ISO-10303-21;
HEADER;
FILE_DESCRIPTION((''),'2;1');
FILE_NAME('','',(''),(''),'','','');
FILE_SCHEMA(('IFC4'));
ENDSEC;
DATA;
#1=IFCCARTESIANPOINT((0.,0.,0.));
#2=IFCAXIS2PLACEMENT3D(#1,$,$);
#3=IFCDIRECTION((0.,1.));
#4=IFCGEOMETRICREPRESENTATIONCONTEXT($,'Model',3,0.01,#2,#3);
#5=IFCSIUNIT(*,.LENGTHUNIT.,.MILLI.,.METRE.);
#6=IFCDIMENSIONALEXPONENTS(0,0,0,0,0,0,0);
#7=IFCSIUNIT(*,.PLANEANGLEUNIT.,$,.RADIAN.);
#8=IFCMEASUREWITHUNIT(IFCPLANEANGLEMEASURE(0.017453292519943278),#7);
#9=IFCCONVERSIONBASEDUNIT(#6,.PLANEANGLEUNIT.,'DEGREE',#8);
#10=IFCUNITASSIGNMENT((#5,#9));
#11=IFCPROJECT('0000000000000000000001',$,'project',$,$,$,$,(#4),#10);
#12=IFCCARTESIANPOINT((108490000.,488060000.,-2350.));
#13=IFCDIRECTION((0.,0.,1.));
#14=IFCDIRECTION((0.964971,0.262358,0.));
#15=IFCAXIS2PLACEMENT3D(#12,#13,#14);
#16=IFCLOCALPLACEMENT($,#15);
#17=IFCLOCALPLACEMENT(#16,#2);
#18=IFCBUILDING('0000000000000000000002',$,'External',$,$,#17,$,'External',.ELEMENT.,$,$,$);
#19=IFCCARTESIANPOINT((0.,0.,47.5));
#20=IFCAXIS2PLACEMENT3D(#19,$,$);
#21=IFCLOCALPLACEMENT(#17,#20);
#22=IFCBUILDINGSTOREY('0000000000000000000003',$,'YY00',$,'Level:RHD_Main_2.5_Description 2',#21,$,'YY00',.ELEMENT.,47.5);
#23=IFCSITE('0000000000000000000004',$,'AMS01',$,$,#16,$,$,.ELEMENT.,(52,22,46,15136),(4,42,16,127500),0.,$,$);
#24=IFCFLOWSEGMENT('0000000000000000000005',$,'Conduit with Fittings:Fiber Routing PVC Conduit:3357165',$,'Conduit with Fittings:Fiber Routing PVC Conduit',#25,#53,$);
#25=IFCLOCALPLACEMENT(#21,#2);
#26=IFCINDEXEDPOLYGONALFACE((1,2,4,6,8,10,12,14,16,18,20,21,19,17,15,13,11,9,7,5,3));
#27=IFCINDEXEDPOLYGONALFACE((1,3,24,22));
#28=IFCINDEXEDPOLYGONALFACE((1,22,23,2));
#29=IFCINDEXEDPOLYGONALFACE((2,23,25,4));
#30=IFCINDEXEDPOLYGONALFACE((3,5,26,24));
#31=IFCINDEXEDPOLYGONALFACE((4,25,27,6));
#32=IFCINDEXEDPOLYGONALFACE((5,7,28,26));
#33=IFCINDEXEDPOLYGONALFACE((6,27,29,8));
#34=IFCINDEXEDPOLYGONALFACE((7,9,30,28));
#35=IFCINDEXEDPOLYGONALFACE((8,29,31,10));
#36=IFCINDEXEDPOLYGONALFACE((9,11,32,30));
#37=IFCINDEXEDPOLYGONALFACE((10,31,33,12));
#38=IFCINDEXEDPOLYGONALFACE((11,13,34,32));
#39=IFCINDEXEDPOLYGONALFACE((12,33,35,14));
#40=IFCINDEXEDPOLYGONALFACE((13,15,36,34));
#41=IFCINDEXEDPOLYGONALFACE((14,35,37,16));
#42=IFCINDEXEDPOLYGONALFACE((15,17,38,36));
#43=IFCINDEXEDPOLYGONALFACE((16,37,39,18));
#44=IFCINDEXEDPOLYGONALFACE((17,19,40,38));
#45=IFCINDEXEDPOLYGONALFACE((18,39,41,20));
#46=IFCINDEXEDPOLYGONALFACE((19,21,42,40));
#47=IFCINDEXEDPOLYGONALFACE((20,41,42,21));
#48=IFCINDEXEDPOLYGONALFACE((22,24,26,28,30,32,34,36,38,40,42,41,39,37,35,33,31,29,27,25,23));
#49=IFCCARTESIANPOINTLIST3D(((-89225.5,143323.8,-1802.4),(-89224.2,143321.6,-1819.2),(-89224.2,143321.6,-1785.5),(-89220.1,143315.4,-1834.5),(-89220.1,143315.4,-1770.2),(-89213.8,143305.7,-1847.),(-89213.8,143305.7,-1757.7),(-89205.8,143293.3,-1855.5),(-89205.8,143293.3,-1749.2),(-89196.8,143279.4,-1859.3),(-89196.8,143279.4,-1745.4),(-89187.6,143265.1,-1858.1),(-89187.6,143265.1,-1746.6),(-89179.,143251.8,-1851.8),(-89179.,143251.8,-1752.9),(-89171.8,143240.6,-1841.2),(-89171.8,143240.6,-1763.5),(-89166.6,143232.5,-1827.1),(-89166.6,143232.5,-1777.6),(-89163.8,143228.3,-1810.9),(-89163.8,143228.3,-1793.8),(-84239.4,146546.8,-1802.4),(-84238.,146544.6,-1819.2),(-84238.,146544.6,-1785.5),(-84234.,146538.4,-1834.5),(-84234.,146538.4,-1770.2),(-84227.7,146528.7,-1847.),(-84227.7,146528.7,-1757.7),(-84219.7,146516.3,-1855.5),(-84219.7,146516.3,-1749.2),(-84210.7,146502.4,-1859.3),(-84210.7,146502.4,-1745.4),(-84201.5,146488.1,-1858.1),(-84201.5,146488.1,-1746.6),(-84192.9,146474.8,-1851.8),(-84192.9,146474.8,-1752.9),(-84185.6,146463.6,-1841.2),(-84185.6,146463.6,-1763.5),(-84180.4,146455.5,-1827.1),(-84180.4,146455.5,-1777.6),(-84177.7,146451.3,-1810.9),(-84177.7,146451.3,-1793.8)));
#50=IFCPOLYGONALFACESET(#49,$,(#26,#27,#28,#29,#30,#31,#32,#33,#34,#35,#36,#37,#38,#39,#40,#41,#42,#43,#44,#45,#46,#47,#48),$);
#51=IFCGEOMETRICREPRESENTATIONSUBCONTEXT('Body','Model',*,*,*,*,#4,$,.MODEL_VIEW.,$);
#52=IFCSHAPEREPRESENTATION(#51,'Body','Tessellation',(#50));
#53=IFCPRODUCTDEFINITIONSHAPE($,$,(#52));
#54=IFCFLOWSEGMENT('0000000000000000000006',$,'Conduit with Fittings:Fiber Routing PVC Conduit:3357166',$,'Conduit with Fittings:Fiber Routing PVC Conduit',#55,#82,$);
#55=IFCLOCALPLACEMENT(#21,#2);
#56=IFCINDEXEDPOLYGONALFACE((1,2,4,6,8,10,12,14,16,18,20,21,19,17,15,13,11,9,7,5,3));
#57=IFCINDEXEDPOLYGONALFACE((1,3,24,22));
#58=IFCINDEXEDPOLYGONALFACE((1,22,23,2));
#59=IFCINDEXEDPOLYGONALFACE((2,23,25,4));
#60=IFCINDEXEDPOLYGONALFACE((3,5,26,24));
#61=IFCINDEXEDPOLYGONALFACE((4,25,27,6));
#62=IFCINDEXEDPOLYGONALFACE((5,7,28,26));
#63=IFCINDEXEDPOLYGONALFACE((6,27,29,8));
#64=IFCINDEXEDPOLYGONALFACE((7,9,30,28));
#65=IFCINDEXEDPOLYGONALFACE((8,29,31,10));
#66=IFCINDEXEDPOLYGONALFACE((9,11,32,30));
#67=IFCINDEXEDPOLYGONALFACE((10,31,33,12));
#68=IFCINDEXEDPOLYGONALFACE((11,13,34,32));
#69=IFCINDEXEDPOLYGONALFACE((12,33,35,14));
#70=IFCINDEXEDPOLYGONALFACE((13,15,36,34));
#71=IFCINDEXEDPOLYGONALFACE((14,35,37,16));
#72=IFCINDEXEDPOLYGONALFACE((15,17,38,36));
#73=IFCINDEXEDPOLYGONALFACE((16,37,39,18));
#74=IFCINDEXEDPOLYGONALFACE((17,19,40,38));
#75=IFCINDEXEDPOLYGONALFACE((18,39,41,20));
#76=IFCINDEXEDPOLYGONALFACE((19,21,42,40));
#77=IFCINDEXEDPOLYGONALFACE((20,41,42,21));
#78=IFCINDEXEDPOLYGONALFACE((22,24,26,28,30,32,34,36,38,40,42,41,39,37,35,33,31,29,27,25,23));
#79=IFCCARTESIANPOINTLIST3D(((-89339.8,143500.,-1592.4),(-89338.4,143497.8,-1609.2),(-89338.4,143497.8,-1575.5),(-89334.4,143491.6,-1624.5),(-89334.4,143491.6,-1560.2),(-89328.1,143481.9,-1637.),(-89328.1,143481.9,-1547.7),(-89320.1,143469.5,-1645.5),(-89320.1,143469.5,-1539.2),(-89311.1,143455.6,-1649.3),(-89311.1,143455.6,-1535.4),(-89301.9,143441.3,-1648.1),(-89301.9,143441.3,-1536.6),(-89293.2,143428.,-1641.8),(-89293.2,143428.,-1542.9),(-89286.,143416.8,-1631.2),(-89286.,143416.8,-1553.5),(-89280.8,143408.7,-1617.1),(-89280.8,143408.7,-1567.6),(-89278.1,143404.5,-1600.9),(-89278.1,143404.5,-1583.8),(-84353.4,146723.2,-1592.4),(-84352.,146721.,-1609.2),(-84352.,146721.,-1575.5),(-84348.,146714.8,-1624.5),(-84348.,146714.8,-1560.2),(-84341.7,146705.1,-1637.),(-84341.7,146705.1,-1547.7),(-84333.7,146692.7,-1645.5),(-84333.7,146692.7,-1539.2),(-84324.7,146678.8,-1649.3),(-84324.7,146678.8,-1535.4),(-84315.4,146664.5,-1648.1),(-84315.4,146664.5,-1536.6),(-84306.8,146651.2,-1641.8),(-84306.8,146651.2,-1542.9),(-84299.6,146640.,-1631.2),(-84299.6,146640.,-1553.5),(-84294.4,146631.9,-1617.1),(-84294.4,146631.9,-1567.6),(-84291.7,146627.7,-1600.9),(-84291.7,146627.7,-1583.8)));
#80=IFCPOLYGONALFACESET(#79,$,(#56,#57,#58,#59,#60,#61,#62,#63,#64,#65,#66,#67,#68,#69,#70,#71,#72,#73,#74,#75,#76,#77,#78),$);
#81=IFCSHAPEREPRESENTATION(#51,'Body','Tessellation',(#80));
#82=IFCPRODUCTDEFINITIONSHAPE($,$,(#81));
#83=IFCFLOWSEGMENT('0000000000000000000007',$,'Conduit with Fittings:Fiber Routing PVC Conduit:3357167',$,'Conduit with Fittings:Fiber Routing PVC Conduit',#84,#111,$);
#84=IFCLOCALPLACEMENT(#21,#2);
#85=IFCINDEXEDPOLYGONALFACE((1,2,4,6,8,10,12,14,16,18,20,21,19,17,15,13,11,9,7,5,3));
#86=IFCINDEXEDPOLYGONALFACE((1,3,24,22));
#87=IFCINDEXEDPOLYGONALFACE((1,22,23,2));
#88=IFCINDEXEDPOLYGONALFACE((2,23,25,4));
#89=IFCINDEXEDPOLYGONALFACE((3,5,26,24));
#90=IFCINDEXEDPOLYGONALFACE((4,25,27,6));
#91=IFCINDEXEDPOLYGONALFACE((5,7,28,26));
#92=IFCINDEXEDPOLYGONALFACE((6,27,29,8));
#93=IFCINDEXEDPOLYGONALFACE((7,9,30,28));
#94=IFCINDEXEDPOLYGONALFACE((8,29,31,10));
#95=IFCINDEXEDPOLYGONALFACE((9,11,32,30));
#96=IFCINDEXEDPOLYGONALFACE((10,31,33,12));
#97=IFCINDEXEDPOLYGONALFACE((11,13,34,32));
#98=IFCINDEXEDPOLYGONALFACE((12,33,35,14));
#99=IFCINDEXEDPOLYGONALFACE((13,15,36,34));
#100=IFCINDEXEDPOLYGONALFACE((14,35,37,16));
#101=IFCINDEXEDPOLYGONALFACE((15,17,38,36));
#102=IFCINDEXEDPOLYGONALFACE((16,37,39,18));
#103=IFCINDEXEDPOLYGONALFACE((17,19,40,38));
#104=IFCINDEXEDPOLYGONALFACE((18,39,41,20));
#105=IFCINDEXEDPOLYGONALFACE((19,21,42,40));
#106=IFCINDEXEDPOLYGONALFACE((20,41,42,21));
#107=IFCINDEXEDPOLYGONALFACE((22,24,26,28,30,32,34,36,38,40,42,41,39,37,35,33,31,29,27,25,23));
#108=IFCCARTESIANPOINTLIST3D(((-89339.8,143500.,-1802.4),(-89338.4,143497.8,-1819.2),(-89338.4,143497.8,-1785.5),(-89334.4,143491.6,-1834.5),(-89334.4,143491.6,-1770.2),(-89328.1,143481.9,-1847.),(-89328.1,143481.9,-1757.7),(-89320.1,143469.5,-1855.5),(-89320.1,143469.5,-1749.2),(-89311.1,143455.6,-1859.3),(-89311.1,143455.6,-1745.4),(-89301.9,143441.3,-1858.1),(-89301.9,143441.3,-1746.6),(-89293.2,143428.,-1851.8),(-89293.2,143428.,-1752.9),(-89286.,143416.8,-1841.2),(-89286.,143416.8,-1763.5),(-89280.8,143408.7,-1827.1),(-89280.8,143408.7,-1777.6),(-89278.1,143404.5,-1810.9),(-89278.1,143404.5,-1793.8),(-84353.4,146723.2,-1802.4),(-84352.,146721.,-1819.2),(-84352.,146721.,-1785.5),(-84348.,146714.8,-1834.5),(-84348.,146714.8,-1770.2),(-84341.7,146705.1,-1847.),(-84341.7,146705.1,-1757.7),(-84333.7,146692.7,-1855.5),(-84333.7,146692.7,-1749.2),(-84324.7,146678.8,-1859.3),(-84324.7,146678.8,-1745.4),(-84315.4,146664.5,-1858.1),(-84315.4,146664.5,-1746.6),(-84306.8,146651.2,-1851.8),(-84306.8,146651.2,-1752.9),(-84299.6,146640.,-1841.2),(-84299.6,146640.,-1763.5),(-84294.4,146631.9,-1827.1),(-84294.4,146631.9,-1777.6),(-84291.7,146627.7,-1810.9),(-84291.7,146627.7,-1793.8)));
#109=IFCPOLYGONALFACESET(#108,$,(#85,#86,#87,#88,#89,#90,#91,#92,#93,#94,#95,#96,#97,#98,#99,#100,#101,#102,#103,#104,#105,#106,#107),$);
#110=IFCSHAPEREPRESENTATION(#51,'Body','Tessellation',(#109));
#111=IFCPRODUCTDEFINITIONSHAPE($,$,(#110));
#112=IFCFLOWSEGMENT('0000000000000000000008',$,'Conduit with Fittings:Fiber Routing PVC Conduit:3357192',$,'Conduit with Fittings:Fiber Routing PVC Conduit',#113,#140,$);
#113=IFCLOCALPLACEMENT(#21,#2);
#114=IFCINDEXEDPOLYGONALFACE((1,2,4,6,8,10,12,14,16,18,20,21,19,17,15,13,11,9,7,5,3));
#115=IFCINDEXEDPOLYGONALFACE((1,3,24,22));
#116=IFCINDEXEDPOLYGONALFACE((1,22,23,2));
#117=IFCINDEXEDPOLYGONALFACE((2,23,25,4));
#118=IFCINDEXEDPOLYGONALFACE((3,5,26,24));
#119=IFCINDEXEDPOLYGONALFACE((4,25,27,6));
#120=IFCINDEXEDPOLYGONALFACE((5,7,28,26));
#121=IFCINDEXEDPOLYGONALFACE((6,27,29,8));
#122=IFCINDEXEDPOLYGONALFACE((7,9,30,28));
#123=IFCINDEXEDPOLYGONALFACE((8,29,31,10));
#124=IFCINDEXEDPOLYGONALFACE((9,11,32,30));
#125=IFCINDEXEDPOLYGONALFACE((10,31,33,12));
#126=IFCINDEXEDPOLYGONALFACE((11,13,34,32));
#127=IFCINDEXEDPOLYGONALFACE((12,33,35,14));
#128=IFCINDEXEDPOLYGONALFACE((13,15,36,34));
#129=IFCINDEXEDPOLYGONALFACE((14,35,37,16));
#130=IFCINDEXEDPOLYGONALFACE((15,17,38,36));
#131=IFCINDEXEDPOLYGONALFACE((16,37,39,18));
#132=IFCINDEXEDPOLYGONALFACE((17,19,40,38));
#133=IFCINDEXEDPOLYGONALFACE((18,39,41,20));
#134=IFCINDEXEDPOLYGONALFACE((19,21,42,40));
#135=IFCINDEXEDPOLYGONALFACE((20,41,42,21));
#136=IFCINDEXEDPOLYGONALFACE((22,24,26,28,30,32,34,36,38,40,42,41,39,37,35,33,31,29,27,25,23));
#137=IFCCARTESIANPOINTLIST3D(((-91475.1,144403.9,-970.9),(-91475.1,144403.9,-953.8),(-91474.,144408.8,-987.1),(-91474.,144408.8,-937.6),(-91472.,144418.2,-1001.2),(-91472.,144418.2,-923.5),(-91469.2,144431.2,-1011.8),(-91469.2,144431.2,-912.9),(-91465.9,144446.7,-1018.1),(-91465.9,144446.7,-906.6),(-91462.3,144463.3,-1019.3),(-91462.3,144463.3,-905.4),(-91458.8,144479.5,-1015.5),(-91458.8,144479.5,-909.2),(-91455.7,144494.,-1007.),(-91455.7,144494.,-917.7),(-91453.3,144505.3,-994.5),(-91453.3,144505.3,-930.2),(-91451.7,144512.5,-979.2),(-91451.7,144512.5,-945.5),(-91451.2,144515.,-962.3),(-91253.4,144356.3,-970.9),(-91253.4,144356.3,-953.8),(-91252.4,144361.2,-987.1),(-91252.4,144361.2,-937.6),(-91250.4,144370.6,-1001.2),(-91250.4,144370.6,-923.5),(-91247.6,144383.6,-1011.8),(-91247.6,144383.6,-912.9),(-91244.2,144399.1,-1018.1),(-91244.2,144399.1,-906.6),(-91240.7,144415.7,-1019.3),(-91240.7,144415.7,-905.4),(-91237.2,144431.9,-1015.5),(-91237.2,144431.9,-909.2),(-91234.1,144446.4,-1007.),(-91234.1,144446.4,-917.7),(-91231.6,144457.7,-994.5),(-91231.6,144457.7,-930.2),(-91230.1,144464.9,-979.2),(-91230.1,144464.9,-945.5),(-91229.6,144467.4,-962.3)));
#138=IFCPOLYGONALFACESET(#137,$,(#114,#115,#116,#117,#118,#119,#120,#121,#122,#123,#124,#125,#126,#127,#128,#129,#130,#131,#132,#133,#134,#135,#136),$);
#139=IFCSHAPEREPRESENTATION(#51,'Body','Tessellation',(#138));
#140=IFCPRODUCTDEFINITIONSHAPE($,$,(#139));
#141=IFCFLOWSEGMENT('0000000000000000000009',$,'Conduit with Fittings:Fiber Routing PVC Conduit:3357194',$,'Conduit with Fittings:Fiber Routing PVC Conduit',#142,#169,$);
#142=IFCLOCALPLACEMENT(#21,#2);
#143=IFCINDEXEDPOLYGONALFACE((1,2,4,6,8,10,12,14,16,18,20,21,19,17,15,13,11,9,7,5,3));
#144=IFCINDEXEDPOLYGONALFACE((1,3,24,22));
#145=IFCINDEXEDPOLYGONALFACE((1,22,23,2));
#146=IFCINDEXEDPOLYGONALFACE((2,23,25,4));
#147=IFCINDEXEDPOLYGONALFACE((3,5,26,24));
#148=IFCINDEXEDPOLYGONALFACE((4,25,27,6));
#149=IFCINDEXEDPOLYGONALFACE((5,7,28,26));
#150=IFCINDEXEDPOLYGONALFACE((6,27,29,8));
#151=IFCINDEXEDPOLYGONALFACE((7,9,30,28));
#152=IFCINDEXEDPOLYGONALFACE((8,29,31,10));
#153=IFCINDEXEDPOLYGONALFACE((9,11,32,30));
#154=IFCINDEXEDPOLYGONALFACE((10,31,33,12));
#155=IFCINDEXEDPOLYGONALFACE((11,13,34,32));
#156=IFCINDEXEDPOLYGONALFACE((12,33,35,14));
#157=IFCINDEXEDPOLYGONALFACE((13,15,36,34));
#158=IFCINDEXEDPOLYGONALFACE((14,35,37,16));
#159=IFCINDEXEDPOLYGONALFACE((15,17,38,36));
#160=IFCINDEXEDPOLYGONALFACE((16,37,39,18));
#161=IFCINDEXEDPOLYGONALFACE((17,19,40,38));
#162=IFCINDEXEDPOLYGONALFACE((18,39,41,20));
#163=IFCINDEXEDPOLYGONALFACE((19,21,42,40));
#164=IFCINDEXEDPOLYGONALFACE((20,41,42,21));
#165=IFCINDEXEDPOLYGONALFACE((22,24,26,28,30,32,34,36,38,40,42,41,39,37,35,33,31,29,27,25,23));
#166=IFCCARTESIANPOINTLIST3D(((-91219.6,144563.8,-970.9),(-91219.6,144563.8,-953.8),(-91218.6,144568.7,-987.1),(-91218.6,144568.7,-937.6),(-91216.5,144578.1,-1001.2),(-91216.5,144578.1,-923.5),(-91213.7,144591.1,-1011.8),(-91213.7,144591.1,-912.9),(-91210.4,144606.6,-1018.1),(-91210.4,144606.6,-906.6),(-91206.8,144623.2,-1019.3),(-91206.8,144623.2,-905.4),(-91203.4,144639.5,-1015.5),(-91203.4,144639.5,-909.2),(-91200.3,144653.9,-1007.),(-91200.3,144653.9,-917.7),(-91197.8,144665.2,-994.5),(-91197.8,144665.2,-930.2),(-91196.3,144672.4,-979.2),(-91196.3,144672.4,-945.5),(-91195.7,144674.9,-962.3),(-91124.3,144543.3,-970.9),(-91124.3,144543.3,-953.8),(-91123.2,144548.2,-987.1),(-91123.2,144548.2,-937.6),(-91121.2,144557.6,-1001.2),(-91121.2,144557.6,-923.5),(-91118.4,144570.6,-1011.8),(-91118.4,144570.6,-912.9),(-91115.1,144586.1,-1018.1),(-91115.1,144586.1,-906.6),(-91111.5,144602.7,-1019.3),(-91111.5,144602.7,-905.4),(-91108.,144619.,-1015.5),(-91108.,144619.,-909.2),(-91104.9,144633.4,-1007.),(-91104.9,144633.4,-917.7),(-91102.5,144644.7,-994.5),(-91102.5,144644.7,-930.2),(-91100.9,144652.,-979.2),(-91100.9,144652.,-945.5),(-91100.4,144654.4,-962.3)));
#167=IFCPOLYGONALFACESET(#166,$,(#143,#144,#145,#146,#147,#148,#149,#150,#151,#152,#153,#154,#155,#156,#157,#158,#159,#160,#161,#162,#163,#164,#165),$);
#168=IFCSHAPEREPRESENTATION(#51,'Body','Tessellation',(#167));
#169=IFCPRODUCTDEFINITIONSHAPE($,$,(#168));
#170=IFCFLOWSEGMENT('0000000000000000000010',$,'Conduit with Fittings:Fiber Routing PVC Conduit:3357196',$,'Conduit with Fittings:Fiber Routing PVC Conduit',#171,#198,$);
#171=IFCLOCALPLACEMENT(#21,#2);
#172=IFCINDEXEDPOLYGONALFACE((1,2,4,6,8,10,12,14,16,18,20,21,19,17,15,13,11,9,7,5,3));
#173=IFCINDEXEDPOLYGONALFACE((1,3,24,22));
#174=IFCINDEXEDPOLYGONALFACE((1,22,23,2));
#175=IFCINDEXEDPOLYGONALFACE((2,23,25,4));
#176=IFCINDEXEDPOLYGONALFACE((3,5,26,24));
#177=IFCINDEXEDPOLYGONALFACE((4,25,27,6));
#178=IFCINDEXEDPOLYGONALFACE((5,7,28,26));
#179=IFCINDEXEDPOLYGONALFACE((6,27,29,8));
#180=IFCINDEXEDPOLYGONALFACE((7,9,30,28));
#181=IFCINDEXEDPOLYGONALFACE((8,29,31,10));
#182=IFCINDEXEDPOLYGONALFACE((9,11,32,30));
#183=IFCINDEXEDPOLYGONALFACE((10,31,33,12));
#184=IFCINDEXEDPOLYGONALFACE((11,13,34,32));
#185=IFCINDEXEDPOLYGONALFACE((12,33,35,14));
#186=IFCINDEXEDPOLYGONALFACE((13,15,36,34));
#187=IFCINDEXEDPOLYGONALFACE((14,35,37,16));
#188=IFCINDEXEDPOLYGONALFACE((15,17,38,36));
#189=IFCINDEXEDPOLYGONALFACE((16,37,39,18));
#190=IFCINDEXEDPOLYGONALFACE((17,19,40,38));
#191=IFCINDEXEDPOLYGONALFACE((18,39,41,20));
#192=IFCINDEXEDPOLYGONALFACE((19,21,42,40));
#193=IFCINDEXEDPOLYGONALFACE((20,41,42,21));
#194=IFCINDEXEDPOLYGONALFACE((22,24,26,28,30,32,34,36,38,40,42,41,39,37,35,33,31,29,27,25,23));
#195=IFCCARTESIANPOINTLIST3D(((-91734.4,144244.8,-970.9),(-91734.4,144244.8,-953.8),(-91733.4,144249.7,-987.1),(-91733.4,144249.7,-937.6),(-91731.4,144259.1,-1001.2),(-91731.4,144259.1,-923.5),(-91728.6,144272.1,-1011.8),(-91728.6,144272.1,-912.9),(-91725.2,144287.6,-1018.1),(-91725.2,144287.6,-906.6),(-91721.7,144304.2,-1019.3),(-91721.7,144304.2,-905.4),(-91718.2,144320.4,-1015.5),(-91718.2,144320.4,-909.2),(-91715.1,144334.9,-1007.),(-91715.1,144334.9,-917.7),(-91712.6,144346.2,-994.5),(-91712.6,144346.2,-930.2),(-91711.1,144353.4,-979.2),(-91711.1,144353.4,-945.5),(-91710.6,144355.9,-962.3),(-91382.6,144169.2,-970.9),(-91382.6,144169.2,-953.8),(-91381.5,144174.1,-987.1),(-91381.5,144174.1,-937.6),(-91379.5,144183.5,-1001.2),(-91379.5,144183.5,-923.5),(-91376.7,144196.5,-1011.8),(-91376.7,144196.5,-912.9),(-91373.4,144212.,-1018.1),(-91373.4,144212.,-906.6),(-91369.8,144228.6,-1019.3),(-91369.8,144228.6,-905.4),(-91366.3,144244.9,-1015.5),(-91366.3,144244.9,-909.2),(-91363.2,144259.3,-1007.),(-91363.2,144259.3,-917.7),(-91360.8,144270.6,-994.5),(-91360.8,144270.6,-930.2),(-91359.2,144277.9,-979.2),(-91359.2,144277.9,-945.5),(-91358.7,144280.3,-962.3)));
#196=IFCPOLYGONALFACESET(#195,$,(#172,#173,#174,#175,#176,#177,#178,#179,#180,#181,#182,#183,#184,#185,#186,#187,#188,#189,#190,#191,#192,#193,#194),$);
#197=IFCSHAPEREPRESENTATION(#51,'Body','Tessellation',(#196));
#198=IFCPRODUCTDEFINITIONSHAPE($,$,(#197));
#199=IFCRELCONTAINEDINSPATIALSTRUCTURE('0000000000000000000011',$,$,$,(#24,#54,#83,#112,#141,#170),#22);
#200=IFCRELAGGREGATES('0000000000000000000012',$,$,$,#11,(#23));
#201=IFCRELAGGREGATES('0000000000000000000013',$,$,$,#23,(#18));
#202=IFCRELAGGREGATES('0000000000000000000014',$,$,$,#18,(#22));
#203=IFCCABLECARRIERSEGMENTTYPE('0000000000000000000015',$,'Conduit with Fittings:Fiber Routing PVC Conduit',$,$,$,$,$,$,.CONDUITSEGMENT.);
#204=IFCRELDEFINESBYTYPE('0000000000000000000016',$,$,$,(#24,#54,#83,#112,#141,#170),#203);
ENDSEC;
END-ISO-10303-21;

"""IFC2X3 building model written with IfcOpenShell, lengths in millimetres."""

from ifc_helpers import new_model, entity, si_unit, converted_unit, direction, frame, frame_2d, origin, origin_2d_with_axis, place, context, subcontext, project, spatial, circle, extrude, type_object, element, save


model = new_model("IFC2X3")

# Units and contexts
model_context = context("Model", 3, precision=0.01, world=origin(), true_north=direction((0.0, 1.0)))
body_context = subcontext(model_context, "Body", "Model", "MODEL_VIEW")
ifc_project = project(units=[si_unit("LENGTHUNIT", "METRE", prefix="MILLI"), converted_unit("PLANEANGLEUNIT", "DEGREE", entity("IfcPlaneAngleMeasure", 0.017453292519943278), si_unit("PLANEANGLEUNIT", "RADIAN"), dimensions=[0, 0, 0, 0, 0, 0, 0])], contexts=[model_context])

# Site, building, storey
site_placement = place(None, frame((108490000.0, 488060000.0, -2350.0), z_axis=(0.0, 0.0, 1.0), x_axis=(0.964971, 0.262358, 0.0)))
site = spatial("IfcSite", under=ifc_project, at=site_placement, Name="AMS01", CompositionType="ELEMENT", RefLatitude=(52, 22, 46, 15136), RefLongitude=(4, 42, 16, 127500), RefElevation=0.0)
building_placement = place(site_placement, origin())
building = spatial("IfcBuilding", under=site, at=building_placement, Name="External", LongName="External", CompositionType="ELEMENT")
storey_placement = place(building_placement, frame((0.0, 0.0, 47.5)))
storey = spatial("IfcBuildingStorey", under=building, at=storey_placement, Name="YY00", ObjectType="Level:RHD_Main_2.5_Description 2", LongName="YY00", CompositionType="ELEMENT", Elevation=47.5)

# Flow segments
cable_carrier_segment_type = type_object("IfcCableCarrierSegmentType", Name="Conduit with Fittings:Fiber Routing PVC Conduit", PredefinedType="CONDUITSEGMENT")
flow_segment_1_placement = place(storey_placement, origin())
element("IfcFlowSegment", 1, at=flow_segment_1_placement, inside=storey, type_object=cable_carrier_segment_type, Name="Conduit with Fittings:Fiber Routing PVC Conduit:3357165", ObjectType="Conduit with Fittings:Fiber Routing PVC Conduit", context=body_context, shape_type="SweptSolid", body=[
    extrude(circle(Radius=57.2, at=origin_2d_with_axis()), frame((-89194.5, 143275.8, -1802.4), z_axis=(0.839826, 0.542856, 0.0), x_axis=(-0.542856, 0.839826, 0.0)), (0.0, 0.0, 1.0), 5937.1),
])
flow_segment_2_placement = place(storey_placement, origin())
element("IfcFlowSegment", 2, at=flow_segment_2_placement, inside=storey, type_object=cable_carrier_segment_type, Name="Conduit with Fittings:Fiber Routing PVC Conduit:3357166", ObjectType="Conduit with Fittings:Fiber Routing PVC Conduit", context=body_context, shape_type="SweptSolid", body=[
    extrude(circle(Radius=57.2, at=origin_2d_with_axis()), frame((-89308.8, 143452.0, -1592.4), z_axis=(0.839826, 0.542856, 0.0), x_axis=(-0.542856, 0.839826, 0.0)), (0.0, 0.0, 1.0), 5937.5),
])
flow_segment_3_placement = place(storey_placement, origin())
element("IfcFlowSegment", 3, at=flow_segment_3_placement, inside=storey, type_object=cable_carrier_segment_type, Name="Conduit with Fittings:Fiber Routing PVC Conduit:3357167", ObjectType="Conduit with Fittings:Fiber Routing PVC Conduit", context=body_context, shape_type="SweptSolid", body=[
    extrude(circle(Radius=57.2, at=origin_2d_with_axis()), frame((-89308.8, 143452.0, -1802.4), z_axis=(0.839826, 0.542856, 0.0), x_axis=(-0.542856, 0.839826, 0.0)), (0.0, 0.0, 1.0), 5937.5),
])
flow_segment_4_placement = place(storey_placement, origin())
element("IfcFlowSegment", 4, at=flow_segment_4_placement, inside=storey, type_object=cable_carrier_segment_type, Name="Conduit with Fittings:Fiber Routing PVC Conduit:3357192", ObjectType="Conduit with Fittings:Fiber Routing PVC Conduit", context=body_context, shape_type="SweptSolid", body=[
    extrude(circle(Radius=57.2, at=origin_2d_with_axis()), frame((-91463.2, 144459.1, -962.3), z_axis=(0.977704, -0.209989, 0.0), x_axis=(0.209989, 0.977704, 0.0)), (0.0, 0.0, 1.0), 226.7),
])
flow_segment_5_placement = place(storey_placement, origin())
element("IfcFlowSegment", 5, at=flow_segment_5_placement, inside=storey, type_object=cable_carrier_segment_type, Name="Conduit with Fittings:Fiber Routing PVC Conduit:3357194", ObjectType="Conduit with Fittings:Fiber Routing PVC Conduit", context=body_context, shape_type="SweptSolid", body=[
    extrude(circle(Radius=57.2, at=frame_2d((0.0, 0.0), x_axis=(1.0, 0.0))), frame((-91207.7, 144619.0, -962.3), z_axis=(0.977704, -0.209989, 0.0), x_axis=(0.209989, 0.977704, 0.0)), (0.0, 0.0, 1.0), 97.5),
])
flow_segment_6_placement = place(storey_placement, origin())
element("IfcFlowSegment", 6, at=flow_segment_6_placement, inside=storey, type_object=cable_carrier_segment_type, Name="Conduit with Fittings:Fiber Routing PVC Conduit:3357196", ObjectType="Conduit with Fittings:Fiber Routing PVC Conduit", context=body_context, shape_type="SweptSolid", body=[
    extrude(circle(Radius=57.2, at=frame_2d((0.0, 0.0), x_axis=(1.0, 0.0))), frame((-91722.6, 144300.0, -962.3), z_axis=(0.977704, -0.209989, 0.0), x_axis=(0.209989, 0.977704, 0.0)), (0.0, 0.0, 1.0), 359.9),
])

save(model, "model.ifc")
